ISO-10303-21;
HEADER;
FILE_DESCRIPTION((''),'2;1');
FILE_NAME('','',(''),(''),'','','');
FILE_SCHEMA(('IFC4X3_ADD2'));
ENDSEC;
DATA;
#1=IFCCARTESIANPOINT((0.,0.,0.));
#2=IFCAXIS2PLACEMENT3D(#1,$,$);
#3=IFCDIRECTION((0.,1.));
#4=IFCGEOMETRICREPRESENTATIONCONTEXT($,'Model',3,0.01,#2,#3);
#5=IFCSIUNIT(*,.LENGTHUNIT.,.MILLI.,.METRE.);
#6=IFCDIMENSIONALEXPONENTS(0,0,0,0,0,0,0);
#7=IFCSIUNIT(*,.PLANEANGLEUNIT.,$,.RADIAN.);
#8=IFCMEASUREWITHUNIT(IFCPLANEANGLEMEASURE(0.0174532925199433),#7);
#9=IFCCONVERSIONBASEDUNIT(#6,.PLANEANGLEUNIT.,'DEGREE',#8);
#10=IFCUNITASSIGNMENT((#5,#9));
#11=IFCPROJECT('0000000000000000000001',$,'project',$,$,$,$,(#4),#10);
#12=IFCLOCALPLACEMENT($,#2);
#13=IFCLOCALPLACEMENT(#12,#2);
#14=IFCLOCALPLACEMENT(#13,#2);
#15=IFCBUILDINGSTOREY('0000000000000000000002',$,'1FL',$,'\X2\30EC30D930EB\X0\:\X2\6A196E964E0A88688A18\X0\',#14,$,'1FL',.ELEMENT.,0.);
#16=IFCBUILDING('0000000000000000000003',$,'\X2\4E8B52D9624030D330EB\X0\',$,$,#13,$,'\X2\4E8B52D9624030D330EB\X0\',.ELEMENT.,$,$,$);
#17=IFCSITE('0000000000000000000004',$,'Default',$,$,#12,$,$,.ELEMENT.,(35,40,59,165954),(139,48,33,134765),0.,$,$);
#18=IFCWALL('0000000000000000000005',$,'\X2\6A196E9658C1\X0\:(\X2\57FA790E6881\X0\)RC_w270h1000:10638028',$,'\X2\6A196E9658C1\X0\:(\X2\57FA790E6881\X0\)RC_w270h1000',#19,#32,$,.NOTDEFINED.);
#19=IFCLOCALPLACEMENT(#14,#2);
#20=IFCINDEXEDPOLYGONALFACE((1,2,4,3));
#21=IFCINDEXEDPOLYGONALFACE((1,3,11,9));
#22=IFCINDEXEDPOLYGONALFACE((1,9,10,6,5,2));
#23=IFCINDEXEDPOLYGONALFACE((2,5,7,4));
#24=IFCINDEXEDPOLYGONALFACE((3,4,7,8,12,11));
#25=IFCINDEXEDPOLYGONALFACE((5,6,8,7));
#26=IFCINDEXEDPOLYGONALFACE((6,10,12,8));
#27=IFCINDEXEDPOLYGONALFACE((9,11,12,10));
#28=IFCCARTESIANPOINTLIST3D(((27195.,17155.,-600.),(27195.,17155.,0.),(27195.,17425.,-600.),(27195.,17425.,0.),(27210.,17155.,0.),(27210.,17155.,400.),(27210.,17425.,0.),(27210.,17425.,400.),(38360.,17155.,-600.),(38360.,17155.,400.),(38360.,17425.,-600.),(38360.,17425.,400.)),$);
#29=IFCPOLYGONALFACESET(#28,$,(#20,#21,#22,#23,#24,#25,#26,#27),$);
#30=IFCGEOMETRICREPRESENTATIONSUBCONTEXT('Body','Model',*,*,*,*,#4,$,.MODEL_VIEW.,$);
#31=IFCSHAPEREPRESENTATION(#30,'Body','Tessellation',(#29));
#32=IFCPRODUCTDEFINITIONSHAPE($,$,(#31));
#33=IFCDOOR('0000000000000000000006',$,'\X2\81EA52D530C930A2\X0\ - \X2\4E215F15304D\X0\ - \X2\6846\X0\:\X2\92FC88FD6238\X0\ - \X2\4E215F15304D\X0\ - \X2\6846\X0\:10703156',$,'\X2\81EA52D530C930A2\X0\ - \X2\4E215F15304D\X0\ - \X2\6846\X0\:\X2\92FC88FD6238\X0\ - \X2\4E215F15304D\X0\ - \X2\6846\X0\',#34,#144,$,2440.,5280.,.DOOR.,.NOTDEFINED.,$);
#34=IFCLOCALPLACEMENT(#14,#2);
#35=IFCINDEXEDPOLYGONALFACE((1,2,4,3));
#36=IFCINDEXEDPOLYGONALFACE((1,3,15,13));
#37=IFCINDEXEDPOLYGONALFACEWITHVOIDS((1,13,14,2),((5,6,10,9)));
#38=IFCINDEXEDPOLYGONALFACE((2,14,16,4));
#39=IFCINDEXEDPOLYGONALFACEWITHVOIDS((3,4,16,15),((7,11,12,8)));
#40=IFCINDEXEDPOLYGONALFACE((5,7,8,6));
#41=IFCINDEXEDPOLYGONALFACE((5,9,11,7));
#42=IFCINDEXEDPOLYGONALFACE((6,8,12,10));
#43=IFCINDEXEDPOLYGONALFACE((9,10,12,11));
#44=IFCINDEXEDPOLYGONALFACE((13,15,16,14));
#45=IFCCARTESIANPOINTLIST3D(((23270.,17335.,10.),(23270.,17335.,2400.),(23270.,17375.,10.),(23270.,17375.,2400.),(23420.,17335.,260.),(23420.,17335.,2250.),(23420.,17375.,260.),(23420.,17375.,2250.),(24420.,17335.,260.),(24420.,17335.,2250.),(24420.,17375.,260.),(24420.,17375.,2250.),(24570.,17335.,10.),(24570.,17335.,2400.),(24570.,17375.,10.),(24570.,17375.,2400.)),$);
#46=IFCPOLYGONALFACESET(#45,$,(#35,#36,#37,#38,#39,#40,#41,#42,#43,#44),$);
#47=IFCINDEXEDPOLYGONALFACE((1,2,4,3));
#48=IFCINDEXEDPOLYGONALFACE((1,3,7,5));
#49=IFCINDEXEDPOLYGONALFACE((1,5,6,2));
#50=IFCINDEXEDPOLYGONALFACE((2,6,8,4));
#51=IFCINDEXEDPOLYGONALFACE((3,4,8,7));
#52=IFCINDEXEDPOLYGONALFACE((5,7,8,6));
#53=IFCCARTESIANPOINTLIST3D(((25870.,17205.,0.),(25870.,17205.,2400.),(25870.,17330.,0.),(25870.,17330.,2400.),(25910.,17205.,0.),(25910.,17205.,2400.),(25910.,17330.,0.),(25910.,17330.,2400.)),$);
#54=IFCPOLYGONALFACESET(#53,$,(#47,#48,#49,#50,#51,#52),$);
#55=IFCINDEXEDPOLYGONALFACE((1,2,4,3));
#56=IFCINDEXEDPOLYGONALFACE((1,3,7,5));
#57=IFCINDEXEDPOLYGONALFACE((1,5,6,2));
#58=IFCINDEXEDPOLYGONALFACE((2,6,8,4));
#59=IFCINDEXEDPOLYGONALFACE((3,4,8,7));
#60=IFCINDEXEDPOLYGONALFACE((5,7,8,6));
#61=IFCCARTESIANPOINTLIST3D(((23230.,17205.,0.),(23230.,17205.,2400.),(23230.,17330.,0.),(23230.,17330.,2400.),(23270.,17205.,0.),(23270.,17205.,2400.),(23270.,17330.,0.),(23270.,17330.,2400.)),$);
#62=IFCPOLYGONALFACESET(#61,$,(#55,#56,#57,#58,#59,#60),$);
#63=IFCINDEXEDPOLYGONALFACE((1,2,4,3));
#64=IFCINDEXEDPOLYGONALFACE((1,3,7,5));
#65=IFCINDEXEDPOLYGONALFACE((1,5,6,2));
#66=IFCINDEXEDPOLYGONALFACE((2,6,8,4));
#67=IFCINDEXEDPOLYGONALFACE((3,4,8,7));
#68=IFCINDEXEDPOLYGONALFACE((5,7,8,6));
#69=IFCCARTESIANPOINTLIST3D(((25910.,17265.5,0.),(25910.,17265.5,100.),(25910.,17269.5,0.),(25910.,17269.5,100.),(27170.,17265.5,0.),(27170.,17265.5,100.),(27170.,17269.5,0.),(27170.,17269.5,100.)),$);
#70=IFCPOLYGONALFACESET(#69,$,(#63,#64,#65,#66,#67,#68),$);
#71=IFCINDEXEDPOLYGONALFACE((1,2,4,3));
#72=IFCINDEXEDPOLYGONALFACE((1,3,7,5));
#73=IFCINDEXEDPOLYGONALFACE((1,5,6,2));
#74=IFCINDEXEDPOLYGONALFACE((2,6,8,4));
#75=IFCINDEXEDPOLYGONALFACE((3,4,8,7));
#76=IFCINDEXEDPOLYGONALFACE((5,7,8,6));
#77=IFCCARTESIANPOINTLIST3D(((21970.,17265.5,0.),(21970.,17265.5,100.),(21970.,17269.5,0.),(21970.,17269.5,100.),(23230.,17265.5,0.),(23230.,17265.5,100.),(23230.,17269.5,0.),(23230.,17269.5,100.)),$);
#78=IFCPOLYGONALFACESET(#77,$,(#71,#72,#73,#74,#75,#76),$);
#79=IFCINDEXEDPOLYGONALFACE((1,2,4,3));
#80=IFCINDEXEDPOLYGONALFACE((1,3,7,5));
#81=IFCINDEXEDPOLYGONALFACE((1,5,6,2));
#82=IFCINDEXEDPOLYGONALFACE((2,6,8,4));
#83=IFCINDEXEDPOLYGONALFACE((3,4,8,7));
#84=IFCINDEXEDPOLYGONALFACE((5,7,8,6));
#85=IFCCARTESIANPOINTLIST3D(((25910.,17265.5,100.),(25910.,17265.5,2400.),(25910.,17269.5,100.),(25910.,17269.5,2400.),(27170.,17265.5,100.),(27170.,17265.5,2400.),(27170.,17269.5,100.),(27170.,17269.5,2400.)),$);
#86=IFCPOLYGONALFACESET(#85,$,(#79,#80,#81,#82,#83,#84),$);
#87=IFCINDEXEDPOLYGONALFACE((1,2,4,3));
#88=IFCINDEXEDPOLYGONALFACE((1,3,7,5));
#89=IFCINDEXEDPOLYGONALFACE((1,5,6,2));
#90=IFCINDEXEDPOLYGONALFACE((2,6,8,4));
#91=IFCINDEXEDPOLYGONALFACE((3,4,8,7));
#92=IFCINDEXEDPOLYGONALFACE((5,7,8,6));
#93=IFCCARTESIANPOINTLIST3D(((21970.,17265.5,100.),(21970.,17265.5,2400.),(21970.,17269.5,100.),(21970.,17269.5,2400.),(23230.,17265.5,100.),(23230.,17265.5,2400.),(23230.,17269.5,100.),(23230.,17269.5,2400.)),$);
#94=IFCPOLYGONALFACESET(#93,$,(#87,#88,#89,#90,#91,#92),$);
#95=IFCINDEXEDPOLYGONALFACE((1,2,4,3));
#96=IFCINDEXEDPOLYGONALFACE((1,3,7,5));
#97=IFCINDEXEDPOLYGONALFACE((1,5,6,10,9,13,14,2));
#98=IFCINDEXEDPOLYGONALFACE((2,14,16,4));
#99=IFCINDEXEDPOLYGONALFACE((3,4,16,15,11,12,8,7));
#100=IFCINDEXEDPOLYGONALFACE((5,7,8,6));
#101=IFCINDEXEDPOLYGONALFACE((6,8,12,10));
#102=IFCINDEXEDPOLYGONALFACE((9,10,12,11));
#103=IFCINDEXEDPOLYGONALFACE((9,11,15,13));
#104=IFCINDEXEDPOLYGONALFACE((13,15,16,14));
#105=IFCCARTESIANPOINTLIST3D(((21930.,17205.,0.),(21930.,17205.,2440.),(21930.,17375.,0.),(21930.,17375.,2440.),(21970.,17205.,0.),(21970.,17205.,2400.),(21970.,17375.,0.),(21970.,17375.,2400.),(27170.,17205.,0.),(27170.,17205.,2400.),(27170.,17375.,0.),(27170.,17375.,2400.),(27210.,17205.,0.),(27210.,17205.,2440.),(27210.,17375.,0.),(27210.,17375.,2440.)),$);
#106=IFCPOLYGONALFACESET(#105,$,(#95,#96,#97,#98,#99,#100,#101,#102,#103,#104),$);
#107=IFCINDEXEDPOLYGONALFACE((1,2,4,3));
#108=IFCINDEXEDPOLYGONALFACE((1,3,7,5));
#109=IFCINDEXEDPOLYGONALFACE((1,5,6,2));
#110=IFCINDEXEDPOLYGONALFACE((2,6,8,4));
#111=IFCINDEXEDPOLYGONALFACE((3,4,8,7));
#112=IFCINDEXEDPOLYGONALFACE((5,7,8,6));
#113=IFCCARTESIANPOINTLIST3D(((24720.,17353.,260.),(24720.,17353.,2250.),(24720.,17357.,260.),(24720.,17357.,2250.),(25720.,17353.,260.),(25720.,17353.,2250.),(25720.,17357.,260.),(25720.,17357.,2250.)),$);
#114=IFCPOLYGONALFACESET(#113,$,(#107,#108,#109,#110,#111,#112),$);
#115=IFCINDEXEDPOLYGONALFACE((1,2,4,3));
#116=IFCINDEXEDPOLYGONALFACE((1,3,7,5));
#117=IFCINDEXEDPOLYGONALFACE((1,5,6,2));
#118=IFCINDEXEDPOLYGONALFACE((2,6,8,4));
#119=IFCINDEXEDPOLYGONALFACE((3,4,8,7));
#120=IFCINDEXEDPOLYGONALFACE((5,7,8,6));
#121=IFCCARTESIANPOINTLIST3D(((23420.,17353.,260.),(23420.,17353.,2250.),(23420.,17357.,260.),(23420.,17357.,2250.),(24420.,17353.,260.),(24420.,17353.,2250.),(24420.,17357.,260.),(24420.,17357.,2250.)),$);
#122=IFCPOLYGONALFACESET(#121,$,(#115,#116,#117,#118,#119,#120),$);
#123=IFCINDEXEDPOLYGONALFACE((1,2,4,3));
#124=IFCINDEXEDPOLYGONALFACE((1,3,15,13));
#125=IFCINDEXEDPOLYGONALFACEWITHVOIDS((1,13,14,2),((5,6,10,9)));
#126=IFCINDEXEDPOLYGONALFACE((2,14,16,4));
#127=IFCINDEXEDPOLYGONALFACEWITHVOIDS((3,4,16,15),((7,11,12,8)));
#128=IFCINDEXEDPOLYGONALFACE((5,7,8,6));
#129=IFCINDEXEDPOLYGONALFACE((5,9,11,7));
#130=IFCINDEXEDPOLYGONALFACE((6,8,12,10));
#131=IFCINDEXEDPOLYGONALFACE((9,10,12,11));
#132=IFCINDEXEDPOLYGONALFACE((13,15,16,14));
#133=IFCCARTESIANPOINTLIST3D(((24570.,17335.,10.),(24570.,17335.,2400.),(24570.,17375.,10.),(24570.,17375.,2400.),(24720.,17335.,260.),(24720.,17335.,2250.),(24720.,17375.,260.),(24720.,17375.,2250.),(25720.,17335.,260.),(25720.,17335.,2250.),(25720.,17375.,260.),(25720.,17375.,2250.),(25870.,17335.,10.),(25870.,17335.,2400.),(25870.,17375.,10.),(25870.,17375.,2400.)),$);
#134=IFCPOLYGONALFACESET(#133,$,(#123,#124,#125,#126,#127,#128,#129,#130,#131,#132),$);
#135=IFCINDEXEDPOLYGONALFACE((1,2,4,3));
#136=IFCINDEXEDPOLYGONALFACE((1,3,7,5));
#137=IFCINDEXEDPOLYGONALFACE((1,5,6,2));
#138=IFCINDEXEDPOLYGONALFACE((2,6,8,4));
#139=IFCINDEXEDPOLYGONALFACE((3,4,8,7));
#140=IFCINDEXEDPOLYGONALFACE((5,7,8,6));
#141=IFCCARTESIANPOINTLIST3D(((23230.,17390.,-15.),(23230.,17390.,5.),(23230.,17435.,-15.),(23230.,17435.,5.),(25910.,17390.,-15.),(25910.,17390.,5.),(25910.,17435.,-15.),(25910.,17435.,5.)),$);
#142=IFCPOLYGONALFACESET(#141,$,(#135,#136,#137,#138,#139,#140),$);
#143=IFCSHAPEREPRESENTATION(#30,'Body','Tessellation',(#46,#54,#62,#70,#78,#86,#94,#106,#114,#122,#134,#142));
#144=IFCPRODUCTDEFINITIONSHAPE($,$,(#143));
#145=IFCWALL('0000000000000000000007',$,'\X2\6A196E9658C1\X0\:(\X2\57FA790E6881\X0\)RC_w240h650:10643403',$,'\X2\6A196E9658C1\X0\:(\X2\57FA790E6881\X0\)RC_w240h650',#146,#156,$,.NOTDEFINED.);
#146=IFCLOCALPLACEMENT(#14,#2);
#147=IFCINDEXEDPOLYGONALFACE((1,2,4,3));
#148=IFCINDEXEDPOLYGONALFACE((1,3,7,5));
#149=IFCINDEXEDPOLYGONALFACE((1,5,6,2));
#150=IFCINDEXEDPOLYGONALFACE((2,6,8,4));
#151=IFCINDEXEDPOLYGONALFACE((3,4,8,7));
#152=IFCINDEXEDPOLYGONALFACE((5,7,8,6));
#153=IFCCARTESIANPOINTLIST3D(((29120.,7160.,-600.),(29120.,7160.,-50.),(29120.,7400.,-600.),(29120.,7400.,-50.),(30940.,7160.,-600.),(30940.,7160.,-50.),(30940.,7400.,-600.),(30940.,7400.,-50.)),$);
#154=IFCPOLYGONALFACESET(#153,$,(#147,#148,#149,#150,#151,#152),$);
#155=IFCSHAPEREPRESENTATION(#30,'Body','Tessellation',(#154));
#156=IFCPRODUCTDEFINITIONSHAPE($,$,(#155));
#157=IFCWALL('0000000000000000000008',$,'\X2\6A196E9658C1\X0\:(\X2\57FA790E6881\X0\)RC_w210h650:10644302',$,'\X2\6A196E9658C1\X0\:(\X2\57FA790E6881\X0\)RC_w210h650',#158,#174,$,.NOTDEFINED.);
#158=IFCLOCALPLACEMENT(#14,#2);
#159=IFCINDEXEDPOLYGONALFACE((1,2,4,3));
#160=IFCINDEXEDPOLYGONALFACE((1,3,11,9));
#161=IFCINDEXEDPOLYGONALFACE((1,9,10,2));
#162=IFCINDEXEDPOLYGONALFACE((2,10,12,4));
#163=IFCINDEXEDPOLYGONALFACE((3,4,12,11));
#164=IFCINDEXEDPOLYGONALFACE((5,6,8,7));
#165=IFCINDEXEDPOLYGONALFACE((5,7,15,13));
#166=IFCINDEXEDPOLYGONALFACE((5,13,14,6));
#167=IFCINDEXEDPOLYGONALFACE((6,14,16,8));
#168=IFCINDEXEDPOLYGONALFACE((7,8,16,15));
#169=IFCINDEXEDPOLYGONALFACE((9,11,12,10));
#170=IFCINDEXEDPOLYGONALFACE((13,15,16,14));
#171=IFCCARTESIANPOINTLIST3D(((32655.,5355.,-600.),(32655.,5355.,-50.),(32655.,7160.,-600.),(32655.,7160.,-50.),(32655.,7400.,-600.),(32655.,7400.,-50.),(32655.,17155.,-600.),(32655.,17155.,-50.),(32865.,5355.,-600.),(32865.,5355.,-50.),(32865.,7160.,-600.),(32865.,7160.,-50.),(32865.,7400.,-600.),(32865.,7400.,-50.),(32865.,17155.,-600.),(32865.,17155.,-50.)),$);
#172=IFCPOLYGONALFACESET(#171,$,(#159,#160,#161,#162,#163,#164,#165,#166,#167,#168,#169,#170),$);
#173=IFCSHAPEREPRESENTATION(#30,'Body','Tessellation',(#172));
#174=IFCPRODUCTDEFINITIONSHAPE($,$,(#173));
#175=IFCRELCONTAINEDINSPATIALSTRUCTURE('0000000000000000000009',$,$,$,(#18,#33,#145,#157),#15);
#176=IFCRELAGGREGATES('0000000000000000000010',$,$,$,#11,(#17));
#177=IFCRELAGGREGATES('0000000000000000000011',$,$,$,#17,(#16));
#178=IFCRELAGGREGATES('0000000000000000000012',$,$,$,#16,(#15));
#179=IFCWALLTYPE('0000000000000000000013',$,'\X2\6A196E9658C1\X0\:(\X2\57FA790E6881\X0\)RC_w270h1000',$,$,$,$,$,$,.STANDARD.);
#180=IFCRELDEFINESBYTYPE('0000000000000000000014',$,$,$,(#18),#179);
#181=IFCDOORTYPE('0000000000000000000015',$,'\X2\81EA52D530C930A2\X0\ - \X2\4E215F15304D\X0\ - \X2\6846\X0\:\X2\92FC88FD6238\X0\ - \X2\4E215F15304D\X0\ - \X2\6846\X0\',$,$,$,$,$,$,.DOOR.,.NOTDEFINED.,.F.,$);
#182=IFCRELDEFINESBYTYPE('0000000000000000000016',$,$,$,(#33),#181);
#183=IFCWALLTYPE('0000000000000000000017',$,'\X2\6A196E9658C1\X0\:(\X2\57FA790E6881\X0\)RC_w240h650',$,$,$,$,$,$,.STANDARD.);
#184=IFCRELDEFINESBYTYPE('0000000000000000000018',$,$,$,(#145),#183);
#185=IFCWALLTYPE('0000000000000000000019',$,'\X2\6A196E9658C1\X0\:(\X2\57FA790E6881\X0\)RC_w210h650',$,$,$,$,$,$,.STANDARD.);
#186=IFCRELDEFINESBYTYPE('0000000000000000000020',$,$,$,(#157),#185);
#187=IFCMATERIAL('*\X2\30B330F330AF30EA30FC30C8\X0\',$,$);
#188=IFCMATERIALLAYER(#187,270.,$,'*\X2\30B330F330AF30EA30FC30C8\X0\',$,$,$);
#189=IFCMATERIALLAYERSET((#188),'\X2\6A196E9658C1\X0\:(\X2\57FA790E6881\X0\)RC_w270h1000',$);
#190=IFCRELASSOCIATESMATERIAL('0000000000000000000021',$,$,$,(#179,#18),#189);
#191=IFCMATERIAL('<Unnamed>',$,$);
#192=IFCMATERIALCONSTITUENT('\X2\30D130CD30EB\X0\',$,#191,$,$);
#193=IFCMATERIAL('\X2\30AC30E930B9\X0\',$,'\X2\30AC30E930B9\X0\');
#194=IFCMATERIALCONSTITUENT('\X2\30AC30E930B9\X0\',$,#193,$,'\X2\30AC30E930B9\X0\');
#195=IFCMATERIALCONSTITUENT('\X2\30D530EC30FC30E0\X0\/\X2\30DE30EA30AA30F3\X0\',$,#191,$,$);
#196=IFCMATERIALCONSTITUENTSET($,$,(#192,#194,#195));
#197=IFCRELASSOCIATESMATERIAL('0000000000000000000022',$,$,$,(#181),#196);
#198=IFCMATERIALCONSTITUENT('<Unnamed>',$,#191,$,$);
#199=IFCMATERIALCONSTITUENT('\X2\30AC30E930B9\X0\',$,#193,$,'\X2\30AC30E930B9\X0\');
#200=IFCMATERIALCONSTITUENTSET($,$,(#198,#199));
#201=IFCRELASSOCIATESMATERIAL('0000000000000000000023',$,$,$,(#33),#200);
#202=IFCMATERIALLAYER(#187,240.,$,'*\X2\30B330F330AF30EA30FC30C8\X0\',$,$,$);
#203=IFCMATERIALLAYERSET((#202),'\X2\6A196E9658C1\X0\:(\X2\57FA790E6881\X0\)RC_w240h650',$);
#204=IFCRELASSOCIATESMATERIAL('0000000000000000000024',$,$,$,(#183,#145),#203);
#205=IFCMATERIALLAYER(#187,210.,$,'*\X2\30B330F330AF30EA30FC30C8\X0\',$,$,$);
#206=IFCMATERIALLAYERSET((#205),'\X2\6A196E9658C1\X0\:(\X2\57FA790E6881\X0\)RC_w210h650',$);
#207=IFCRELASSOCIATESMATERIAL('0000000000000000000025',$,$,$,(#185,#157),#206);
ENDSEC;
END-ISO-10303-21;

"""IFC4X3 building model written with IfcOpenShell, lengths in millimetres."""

from ifc_helpers import new_model, entity, si_unit, converted_unit, direction, frame, frame_2d, origin, origin_2d_with_axis, place, context, subcontext, project, spatial, polyline, rectangle, outline, extrude, source, transform, mapped, material, layer, layer_set, constituent, constituent_set, type_object, type_shapes, element, fill, save


model = new_model("IFC4X3")

# Units and contexts
model_context = context("Model", 3, precision=0.01, world=origin(), true_north=direction((0.0, 1.0)))
body_context = subcontext(model_context, "Body", "Model", "MODEL_VIEW")
ifc_project = project(units=[si_unit("LENGTHUNIT", "METRE", prefix="MILLI"), converted_unit("PLANEANGLEUNIT", "DEGREE", entity("IfcPlaneAngleMeasure", 0.0174532925199433), si_unit("PLANEANGLEUNIT", "RADIAN"), dimensions=[0, 0, 0, 0, 0, 0, 0])], contexts=[model_context])

# Site, building, storey
site_placement = place(None, origin())
site = spatial("IfcSite", under=ifc_project, at=site_placement, Name="Default", CompositionType="ELEMENT", RefLatitude=(35, 40, 59, 165954), RefLongitude=(139, 48, 33, 134765), RefElevation=0.0)
building_placement = place(site_placement, origin())
building = spatial("IfcBuilding", under=site, at=building_placement, Name="事務所ビル", LongName="事務所ビル", CompositionType="ELEMENT")
storey_placement = place(building_placement, origin())
storey = spatial("IfcBuildingStorey", under=building, at=storey_placement, Name="1FL", ObjectType="レベル:標準上表記", LongName="1FL", CompositionType="ELEMENT", Elevation=0.0)

# Wall, opening, door
ifc_material_1 = material(Name="*コンクリート")
ifc_layer_1 = layer(ifc_material_1, 270.0, Name="*コンクリート")
ifc_layer_set_1 = layer_set([ifc_layer_1], Name="標準壁:(基礎梁)RC_w270h1000")
wall_type_1 = type_object("IfcWallType", Name="標準壁:(基礎梁)RC_w270h1000", PredefinedType="STANDARD", material=ifc_layer_set_1)
wall_1_placement = place(storey_placement, frame((27195.0, 17290.0, -600.0)))
wall_1 = element("IfcWall", 1, at=wall_1_placement, inside=storey, type_object=wall_type_1, material=ifc_layer_set_1, Name="標準壁:(基礎梁)RC_w270h1000:10638028", ObjectType="標準壁:(基礎梁)RC_w270h1000", PredefinedType="NOTDEFINED", context=body_context, shape_type="SweptSolid", body=[
    extrude(rectangle(XDim=11165.0, YDim=270.0, at=frame_2d((5582.5, 0.0), x_axis=(-1.0, 0.0))), origin(), (0.0, 0.0, 1.0), 1000.0),
])
opening_1_placement = place(wall_1_placement, frame((-5265.0, -135.0, 600.0)))
opening_1 = element("IfcOpeningElement", 2, at=opening_1_placement, cuts=wall_1, PredefinedType="OPENING", context=body_context, shape_type="SweptSolid", body=[
    extrude(rectangle(XDim=2440.0, YDim=5280.0, at=frame_2d((1220.0, 2640.0), x_axis=(1.0, 0.0))), frame((0.0, 0.0, 0.0), z_axis=(0.0, 1.0, 0.0), x_axis=(0.0, 0.0, 1.0)), (0.0, 0.0, 1.0), 270.0),
])
ifc_material_2 = material(Name="<Unnamed>")
ifc_constituent_1 = constituent(ifc_material_2, Name="<Unnamed>")
ifc_material_3 = material(Name="ガラス", Category="ガラス")
ifc_constituent_2 = constituent(ifc_material_3, Name="ガラス", Category="ガラス")
ifc_constituent_set_1 = constituent_set(constituents=[ifc_constituent_1, ifc_constituent_2])
ifc_constituent_3 = constituent(ifc_material_2, Name="パネル")
ifc_constituent_4 = constituent(ifc_material_3, Name="ガラス", Category="ガラス")
ifc_constituent_5 = constituent(ifc_material_2, Name="フレーム/マリオン")
ifc_constituent_set_2 = constituent_set(constituents=[ifc_constituent_3, ifc_constituent_4, ifc_constituent_5])
door_type = type_object("IfcDoorType", Name="自動ドア - 両引き - 框:鋼製戸 - 両引き - 框", OperationType="NOTDEFINED", ParameterTakesPrecedence=False, PredefinedType="DOOR", material=ifc_constituent_set_2)
shared_shape = source(origin(), body_context, "Body", "SweptSolid", [
    extrude(outline(polyline([(-650.0, -1195.0), (650.0, -1195.0), (650.0, 1195.0), (-650.0, 1195.0), (-650.0, -1195.0)]), holes=[polyline([(-500.0, 1045.0), (500.0, 1045.0), (500.0, -945.0), (-500.0, -945.0), (-500.0, 1045.0)])]), frame((1990.0, 180.0, 1205.0), z_axis=(0.0, 1.0, 0.0), x_axis=(-1.0, 0.0, 0.0)), (0.0, 0.0, 1.0), 40.0),
    extrude(rectangle(XDim=125.0, YDim=40.0, at=origin_2d_with_axis()), frame((3960.0, 112.5, 0.0), z_axis=(0.0, 0.0, 1.0), x_axis=(0.0, 1.0, 0.0)), (0.0, 0.0, 1.0), 2400.0),
    extrude(rectangle(XDim=125.0, YDim=40.0, at=frame_2d((0.0, 0.0), x_axis=(1.0, 0.0))), frame((1320.0, 112.5, 0.0), z_axis=(0.0, 0.0, 1.0), x_axis=(0.0, 1.0, 0.0)), (0.0, 0.0, 1.0), 2400.0),
    extrude(rectangle(XDim=4.0, YDim=1260.0, at=frame_2d((0.0, 0.0), x_axis=(1.0, 0.0))), frame((4610.0, 112.5, 0.0), z_axis=(0.0, 0.0, 1.0), x_axis=(0.0, -1.0, 0.0)), (0.0, 0.0, 1.0), 100.0),
    extrude(rectangle(XDim=4.0, YDim=1260.0, at=frame_2d((0.0, 0.0), x_axis=(1.0, 0.0))), frame((670.0, 112.5, 0.0), z_axis=(0.0, 0.0, 1.0), x_axis=(0.0, -1.0, 0.0)), (0.0, 0.0, 1.0), 100.0),
    extrude(rectangle(XDim=4.0, YDim=1260.0, at=frame_2d((0.0, 0.0), x_axis=(1.0, 0.0))), frame((4610.0, 112.5, 100.0), z_axis=(0.0, 0.0, 1.0), x_axis=(0.0, -1.0, 0.0)), (0.0, 0.0, 1.0), 2300.0),
    extrude(rectangle(XDim=4.0, YDim=1260.0, at=frame_2d((0.0, 0.0), x_axis=(1.0, 0.0))), frame((670.0, 112.5, 100.0), z_axis=(0.0, 0.0, 1.0), x_axis=(0.0, -1.0, 0.0)), (0.0, 0.0, 1.0), 2300.0),
    extrude(outline(polyline([(-1210.0, -2640.0), (1230.0, -2640.0), (1230.0, 2640.0), (-1210.0, 2640.0), (-1210.0, 2600.0), (1190.0, 2600.0), (1190.0, -2600.0), (-1210.0, -2600.0), (-1210.0, -2640.0)])), frame((2640.0, 50.0, 1210.0), z_axis=(0.0, 1.0, 0.0), x_axis=(0.0, 0.0, 1.0)), (0.0, 0.0, 1.0), 170.0),
    extrude(rectangle(XDim=4.0, YDim=1000.0, at=frame_2d((0.0, 0.0), x_axis=(1.0, 0.0))), frame((3290.0, 200.0, 260.0), z_axis=(0.0, 0.0, 1.0), x_axis=(0.0, -1.0, 0.0)), (0.0, 0.0, 1.0), 1990.0),
    extrude(rectangle(XDim=4.0, YDim=1000.0, at=frame_2d((0.0, 0.0), x_axis=(1.0, 0.0))), frame((1990.0, 200.0, 260.0), z_axis=(0.0, 0.0, 1.0), x_axis=(0.0, -1.0, 0.0)), (0.0, 0.0, 1.0), 1990.0),
    extrude(outline(polyline([(-650.0, -1195.0), (650.0, -1195.0), (650.0, 1195.0), (-650.0, 1195.0), (-650.0, -1195.0)]), holes=[polyline([(-500.0, 1045.0), (500.0, 1045.0), (500.0, -945.0), (-500.0, -945.0), (-500.0, 1045.0)])]), frame((3290.0, 180.0, 1205.0), z_axis=(0.0, 1.0, 0.0), x_axis=(-1.0, 0.0, 0.0)), (0.0, 0.0, 1.0), 40.0),
    extrude(rectangle(XDim=2680.0, YDim=45.0, at=frame_2d((0.0, 0.0), x_axis=(1.0, 0.0))), frame((2640.0, 257.5, -15.0), z_axis=(0.0, 0.0, 1.0), x_axis=(-1.0, 0.0, 0.0)), (0.0, 0.0, 1.0), 20.0),
])
type_shapes(door_type, [shared_shape])
door_placement = place(opening_1_placement, origin())
door = element("IfcDoor", 3, at=door_placement, inside=storey, type_object=door_type, material=ifc_constituent_set_1, Name="自動ドア - 両引き - 框:鋼製戸 - 両引き - 框:10703156", ObjectType="自動ドア - 両引き - 框:鋼製戸 - 両引き - 框", OperationType="NOTDEFINED", OverallHeight=2440.0, OverallWidth=5280.0, PredefinedType="DOOR", context=body_context, shape_type="MappedRepresentation", body=[
    mapped(shared_shape, transform((0.0, 0.0, 0.0), scale=1.0)),
])
fill(opening_1, door)

# Wall
ifc_layer_2 = layer(ifc_material_1, 240.0, Name="*コンクリート")
ifc_layer_set_2 = layer_set([ifc_layer_2], Name="標準壁:(基礎梁)RC_w240h650")
wall_type_2 = type_object("IfcWallType", Name="標準壁:(基礎梁)RC_w240h650", PredefinedType="STANDARD", material=ifc_layer_set_2)
wall_2_placement = place(storey_placement, frame((29120.0, 7280.0, -600.0)))
element("IfcWall", 4, at=wall_2_placement, inside=storey, type_object=wall_type_2, material=ifc_layer_set_2, Name="標準壁:(基礎梁)RC_w240h650:10643403", ObjectType="標準壁:(基礎梁)RC_w240h650", PredefinedType="NOTDEFINED", context=body_context, shape_type="SweptSolid", body=[
    extrude(rectangle(XDim=1820.0, YDim=240.0, at=frame_2d((910.0, 0.0), x_axis=(-1.0, 0.0))), origin(), (0.0, 0.0, 1.0), 550.0),
])

# Wall, opening
ifc_layer_3 = layer(ifc_material_1, 210.0, Name="*コンクリート")
ifc_layer_set_3 = layer_set([ifc_layer_3], Name="標準壁:(基礎梁)RC_w210h650")
wall_type_3 = type_object("IfcWallType", Name="標準壁:(基礎梁)RC_w210h650", PredefinedType="STANDARD", material=ifc_layer_set_3)
wall_3_placement = place(storey_placement, frame((32760.0, 5355.0, -600.0), z_axis=(0.0, 0.0, 1.0), x_axis=(0.0, 1.0, 0.0)))
wall_3 = element("IfcWall", 5, at=wall_3_placement, inside=storey, type_object=wall_type_3, material=ifc_layer_set_3, Name="標準壁:(基礎梁)RC_w210h650:10644302", ObjectType="標準壁:(基礎梁)RC_w210h650", PredefinedType="NOTDEFINED", context=body_context, shape_type="SweptSolid", body=[
    extrude(rectangle(XDim=11800.0, YDim=210.0, at=frame_2d((5900.0, 0.0), x_axis=(-1.0, 0.0))), origin(), (0.0, 0.0, 1.0), 550.0),
])
opening_2_placement = place(storey_placement, frame((32760.0, 5355.0, -600.0), z_axis=(0.0, 0.0, 1.0), x_axis=(0.0, 1.0, 0.0)))
element("IfcOpeningElement", 6, at=opening_2_placement, cuts=wall_3, PredefinedType="OPENING", context=body_context, shape_type="SweptSolid", body=[
    extrude(rectangle(XDim=550.0, YDim=210.0, at=frame_2d((0.0, 0.0), x_axis=(1.0, 0.0))), frame((1805.0, 0.0, 275.0), z_axis=(1.0, 0.0, 0.0), x_axis=(0.0, 0.0, -1.0)), (0.0, 0.0, 1.0), 240.0),
])

save(model, "model.ifc")
